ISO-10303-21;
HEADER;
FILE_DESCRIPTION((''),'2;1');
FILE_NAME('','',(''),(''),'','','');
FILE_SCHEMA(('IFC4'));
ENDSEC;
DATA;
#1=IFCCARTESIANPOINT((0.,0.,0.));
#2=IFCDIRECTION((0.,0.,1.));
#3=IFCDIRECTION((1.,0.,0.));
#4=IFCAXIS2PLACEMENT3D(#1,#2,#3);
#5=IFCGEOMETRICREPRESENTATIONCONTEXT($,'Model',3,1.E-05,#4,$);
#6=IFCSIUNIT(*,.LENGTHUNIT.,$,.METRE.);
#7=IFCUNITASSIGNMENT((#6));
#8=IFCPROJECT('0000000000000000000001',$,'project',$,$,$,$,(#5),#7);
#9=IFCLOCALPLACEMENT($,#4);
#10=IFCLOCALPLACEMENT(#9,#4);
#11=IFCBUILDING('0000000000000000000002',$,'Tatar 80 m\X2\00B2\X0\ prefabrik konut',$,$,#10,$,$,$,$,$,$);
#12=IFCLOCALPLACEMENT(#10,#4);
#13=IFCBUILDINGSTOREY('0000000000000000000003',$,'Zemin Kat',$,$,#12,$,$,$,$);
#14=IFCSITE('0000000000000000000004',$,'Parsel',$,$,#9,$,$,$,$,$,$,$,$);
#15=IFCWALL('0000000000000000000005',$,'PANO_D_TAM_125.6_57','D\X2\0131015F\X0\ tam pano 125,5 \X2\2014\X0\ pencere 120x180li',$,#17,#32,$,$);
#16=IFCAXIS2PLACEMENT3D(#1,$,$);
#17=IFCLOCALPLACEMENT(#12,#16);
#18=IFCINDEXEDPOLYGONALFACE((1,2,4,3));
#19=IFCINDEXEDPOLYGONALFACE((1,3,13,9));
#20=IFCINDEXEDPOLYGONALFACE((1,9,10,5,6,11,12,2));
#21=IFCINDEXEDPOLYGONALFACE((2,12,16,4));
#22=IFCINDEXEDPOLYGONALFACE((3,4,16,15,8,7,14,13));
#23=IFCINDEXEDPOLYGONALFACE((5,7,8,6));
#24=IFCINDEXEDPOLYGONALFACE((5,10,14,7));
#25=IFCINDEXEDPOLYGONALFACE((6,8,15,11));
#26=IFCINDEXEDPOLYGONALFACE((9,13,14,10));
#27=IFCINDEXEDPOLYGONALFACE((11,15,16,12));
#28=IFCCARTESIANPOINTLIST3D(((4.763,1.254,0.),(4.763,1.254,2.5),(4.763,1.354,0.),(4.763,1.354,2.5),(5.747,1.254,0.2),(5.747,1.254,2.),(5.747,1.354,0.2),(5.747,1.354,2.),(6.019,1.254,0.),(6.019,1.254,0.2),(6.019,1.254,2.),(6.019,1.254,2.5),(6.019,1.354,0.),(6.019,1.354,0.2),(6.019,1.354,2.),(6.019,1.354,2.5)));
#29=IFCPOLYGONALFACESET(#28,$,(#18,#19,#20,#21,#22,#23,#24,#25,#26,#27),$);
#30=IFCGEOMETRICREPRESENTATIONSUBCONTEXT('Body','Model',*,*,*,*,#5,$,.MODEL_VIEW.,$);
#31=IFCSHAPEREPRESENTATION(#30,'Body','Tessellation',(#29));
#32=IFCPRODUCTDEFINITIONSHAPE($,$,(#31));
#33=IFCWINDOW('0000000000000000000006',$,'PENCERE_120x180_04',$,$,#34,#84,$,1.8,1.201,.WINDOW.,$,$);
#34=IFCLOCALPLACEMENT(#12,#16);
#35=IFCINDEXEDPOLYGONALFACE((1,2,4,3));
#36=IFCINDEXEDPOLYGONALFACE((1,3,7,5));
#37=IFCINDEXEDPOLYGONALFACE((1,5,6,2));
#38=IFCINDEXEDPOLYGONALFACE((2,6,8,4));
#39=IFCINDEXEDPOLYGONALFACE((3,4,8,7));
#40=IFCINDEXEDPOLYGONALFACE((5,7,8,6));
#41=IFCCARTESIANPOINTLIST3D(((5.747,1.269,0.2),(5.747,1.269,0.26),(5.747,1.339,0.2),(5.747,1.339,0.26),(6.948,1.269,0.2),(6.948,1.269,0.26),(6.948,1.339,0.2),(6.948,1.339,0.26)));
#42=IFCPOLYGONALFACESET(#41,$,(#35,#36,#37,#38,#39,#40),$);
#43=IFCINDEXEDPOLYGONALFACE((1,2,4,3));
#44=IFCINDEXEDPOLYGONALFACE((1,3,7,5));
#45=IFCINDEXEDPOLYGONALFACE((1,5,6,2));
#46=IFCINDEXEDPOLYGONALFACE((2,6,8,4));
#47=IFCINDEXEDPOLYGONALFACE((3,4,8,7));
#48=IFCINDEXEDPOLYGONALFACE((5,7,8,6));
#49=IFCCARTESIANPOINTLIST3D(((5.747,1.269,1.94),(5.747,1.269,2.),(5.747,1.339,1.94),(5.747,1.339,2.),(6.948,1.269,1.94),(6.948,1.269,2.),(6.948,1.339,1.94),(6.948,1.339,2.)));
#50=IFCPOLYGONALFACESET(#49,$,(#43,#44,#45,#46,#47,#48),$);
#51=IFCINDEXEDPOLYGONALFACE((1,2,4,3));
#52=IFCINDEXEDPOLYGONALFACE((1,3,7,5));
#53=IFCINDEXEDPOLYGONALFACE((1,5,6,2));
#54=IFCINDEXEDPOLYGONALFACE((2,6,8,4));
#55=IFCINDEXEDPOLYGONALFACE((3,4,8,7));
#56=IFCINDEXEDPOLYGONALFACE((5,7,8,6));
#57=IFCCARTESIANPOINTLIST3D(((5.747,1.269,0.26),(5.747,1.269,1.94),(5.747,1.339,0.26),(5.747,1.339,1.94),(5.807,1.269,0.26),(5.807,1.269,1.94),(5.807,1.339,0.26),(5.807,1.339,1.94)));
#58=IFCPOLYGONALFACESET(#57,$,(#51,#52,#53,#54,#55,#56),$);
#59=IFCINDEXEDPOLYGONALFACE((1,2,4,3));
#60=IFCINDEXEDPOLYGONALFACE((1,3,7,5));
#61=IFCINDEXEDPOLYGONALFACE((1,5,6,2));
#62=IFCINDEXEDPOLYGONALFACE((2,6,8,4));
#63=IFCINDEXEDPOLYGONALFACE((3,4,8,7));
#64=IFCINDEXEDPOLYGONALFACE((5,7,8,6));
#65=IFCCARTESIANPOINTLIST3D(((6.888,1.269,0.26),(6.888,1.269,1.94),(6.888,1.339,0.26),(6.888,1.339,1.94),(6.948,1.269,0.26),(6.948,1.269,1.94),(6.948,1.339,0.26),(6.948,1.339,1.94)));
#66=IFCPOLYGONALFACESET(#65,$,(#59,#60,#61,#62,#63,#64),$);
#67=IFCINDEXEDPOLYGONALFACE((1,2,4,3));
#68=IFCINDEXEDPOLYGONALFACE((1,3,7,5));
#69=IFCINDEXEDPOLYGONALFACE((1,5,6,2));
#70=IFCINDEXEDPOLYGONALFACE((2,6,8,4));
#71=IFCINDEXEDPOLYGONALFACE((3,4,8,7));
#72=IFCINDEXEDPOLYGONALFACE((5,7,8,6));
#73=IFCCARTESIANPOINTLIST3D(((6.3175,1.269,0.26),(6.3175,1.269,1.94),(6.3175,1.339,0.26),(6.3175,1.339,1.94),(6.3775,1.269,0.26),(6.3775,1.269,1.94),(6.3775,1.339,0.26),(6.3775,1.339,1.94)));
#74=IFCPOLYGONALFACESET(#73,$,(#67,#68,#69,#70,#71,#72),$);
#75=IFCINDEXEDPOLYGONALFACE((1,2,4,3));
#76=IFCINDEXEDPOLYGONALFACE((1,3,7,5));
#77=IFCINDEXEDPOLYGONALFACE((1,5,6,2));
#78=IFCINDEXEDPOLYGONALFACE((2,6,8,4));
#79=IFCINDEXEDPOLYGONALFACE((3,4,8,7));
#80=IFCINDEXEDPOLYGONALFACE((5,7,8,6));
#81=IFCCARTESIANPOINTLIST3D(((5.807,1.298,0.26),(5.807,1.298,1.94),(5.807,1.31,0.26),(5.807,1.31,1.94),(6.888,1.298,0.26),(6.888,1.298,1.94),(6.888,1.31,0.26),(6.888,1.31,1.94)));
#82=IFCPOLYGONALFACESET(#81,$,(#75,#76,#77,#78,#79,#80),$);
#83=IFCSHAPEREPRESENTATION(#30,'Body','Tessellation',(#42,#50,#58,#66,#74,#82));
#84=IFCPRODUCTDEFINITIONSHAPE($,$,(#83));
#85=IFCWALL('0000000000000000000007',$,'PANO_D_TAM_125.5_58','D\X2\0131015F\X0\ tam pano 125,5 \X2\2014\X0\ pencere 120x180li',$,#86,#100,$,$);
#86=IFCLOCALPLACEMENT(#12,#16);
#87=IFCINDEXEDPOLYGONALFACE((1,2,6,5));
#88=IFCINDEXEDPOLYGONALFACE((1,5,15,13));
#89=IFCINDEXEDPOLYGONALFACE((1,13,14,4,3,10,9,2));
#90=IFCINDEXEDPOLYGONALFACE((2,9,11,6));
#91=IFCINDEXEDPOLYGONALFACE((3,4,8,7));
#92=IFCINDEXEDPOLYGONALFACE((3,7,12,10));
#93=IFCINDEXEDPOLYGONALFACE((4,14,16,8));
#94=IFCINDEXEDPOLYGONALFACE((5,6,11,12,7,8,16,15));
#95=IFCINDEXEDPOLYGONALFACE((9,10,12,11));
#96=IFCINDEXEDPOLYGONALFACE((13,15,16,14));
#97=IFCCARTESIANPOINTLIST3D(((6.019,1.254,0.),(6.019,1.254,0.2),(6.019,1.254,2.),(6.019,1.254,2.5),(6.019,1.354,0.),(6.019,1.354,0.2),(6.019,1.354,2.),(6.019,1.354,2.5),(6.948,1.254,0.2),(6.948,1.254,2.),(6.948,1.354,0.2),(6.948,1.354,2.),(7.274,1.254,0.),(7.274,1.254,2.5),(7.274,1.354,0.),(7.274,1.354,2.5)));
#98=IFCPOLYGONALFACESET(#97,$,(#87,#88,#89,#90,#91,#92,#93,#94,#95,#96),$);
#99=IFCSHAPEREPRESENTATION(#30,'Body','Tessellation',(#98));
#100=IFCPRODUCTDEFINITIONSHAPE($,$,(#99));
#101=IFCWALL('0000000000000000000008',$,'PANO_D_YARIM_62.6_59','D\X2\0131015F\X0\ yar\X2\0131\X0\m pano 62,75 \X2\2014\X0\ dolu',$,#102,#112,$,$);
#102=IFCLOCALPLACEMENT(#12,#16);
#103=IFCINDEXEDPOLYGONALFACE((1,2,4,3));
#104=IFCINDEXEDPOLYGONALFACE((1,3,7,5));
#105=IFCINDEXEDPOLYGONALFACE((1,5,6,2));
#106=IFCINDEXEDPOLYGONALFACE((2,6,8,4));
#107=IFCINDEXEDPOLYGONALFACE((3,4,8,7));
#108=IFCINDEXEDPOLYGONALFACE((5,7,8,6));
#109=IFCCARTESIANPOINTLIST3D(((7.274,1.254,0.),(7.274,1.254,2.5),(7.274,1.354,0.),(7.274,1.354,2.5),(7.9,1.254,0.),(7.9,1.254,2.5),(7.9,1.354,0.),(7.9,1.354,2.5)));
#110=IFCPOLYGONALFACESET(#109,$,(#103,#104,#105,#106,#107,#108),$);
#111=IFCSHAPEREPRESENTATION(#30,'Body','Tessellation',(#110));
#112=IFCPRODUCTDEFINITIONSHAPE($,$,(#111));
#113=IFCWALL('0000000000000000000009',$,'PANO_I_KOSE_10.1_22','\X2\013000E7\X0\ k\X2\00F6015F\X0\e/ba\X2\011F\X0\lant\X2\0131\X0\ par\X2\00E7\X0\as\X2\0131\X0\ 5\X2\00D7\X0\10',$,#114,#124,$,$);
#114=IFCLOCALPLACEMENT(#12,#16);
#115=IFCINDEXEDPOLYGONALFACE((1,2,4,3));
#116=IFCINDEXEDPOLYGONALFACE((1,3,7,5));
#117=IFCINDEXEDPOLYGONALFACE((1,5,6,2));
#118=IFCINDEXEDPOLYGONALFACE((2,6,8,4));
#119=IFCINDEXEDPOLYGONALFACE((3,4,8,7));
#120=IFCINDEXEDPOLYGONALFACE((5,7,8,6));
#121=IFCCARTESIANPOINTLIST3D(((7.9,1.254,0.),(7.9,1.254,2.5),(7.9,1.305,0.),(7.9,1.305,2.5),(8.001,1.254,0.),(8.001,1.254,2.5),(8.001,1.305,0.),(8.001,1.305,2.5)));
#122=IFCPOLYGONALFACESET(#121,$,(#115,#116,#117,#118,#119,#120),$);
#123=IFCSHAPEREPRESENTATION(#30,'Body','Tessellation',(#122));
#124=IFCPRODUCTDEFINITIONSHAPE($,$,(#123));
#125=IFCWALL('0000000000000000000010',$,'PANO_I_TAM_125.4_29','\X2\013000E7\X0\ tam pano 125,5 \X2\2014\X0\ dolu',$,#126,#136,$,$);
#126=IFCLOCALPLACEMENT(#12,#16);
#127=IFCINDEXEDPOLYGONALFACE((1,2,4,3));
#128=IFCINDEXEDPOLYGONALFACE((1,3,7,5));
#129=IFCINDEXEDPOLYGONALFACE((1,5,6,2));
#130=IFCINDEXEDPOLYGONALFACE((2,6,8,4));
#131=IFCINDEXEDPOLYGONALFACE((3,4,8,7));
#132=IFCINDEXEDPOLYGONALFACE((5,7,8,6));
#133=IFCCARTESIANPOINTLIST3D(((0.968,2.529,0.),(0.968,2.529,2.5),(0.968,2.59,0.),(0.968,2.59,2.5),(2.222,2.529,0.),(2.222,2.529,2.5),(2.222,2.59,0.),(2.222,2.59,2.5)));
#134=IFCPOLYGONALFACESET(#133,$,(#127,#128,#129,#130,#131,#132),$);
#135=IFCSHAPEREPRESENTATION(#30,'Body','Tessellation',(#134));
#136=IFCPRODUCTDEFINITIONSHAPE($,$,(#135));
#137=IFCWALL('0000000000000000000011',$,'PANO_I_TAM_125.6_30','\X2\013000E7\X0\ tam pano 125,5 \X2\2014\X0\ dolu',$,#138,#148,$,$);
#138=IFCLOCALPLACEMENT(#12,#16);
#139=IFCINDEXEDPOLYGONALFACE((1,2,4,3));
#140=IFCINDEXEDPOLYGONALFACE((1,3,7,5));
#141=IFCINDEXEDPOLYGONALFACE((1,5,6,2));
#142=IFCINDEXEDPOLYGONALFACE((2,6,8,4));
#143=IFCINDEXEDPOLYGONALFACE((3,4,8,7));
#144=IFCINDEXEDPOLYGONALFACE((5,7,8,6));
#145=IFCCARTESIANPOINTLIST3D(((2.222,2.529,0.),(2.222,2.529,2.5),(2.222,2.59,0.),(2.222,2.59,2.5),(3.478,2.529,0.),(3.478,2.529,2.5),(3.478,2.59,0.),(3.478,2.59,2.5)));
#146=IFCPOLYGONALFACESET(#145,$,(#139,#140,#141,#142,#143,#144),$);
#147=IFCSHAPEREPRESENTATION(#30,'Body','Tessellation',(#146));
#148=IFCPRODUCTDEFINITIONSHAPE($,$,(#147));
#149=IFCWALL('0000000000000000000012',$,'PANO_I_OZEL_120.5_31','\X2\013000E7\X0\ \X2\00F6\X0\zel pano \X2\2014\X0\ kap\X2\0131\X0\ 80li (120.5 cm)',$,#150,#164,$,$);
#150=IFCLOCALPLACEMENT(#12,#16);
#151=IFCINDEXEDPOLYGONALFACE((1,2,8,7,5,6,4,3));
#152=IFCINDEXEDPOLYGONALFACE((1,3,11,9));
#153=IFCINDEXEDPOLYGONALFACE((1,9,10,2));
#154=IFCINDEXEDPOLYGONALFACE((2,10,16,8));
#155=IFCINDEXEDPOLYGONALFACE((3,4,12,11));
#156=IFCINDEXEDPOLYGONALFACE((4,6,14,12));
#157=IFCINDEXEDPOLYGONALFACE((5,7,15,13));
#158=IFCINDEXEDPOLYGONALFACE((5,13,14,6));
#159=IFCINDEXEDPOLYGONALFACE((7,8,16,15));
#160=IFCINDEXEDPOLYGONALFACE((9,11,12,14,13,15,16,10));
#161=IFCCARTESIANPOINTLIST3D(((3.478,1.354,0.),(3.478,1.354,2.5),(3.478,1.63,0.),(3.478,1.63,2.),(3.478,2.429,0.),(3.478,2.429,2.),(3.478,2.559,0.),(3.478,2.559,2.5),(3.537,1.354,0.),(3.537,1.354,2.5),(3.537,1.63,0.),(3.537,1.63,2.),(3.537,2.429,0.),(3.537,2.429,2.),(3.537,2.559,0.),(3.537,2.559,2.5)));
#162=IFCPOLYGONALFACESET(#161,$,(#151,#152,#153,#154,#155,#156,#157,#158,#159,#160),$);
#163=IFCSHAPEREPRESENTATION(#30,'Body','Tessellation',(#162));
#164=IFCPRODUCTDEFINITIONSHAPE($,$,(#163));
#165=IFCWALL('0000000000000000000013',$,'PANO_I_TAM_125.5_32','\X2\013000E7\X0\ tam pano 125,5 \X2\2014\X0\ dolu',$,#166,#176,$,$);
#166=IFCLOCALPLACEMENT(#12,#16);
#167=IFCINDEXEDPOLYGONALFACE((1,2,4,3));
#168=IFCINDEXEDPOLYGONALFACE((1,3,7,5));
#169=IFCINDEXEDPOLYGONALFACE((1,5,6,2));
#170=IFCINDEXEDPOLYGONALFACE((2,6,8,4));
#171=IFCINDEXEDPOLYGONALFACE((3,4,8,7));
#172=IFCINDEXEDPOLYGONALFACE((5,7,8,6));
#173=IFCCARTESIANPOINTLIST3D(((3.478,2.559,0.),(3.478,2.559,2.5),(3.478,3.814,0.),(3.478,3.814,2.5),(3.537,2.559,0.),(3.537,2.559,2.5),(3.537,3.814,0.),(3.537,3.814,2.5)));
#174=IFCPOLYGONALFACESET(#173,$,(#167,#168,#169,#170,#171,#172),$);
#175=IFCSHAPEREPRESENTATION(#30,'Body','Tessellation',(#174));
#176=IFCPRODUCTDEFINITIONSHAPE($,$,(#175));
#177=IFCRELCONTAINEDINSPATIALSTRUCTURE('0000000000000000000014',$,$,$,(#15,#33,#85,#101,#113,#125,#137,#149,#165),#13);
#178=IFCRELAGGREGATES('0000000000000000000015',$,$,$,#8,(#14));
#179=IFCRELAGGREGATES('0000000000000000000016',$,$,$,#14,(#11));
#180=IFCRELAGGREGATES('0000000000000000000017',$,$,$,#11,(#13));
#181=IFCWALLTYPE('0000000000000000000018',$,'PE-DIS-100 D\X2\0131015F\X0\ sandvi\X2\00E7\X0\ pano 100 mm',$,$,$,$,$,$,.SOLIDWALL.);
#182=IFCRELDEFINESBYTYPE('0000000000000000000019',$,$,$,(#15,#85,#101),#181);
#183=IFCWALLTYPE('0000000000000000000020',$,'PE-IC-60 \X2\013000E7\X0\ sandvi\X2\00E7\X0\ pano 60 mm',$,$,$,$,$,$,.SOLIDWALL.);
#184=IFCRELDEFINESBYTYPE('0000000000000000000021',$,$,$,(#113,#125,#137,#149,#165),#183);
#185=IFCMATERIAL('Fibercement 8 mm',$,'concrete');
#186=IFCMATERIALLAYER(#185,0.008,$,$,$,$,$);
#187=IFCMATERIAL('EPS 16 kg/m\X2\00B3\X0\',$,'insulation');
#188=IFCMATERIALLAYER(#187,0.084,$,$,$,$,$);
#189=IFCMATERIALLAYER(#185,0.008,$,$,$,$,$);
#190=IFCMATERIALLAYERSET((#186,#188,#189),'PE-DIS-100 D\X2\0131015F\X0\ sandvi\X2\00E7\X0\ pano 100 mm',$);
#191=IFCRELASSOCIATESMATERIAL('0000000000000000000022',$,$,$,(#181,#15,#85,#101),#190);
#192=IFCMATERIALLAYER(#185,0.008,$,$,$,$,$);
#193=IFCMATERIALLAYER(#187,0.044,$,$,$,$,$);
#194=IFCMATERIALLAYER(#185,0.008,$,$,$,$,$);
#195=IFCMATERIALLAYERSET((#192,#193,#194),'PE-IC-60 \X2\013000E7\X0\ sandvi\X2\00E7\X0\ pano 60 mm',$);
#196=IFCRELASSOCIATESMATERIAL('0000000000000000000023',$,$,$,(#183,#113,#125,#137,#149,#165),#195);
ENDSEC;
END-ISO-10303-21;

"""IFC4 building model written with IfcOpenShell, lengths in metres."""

from ifc_helpers import new_model, si_unit, frame, origin_with_axes, place, context, subcontext, project, spatial, line, indexed_curve, outline, extrude, material, layer, layer_set, layer_usage, type_object, element, fill, save


model = new_model("IFC4")

# Units and contexts
model_context = context("Model", 3, precision=1e-05, world=origin_with_axes())
body_context = subcontext(model_context, "Body", "Model", "MODEL_VIEW")
ifc_project = project(units=[si_unit("LENGTHUNIT", "METRE")], contexts=[model_context])

# Site, building, storey
site_placement = place(None, origin_with_axes())
site = spatial("IfcSite", under=ifc_project, at=site_placement, Name="Parsel")
building_placement = place(site_placement, origin_with_axes())
building = spatial("IfcBuilding", under=site, at=building_placement, Name="Tatar 80 m² prefabrik konut")
storey_placement = place(building_placement, origin_with_axes())
storey = spatial("IfcBuildingStorey", under=building, at=storey_placement, Name="Zemin Kat")

# Shared definitions
ifc_material_1 = material(Name="Fibercement 8 mm", Category="concrete")
ifc_layer_1 = layer(ifc_material_1, 0.008)
ifc_material_2 = material(Name="EPS 16 kg/m³", Category="insulation")
ifc_layer_2 = layer(ifc_material_2, 0.084)
ifc_layer_3 = layer(ifc_material_1, 0.008)
ifc_layer_set_1 = layer_set([ifc_layer_1, ifc_layer_2, ifc_layer_3], Name="PE-DIS-100 Dış sandviç pano 100 mm")
wall_type_1 = type_object("IfcWallType", Name="PE-DIS-100 Dış sandviç pano 100 mm", PredefinedType="SOLIDWALL", material=ifc_layer_set_1)

# Wall, opening, window
ifc_layer_usage_1 = layer_usage(ifc_layer_set_1, "AXIS2", "POSITIVE", 0.0)
wall_1_placement = place(storey_placement, frame((4.763, 1.254, 0.0), z_axis=(0.0, 0.0, 1.0), x_axis=(1.0, 0.0, 0.0)))
wall_1 = element("IfcWall", 1, at=wall_1_placement, inside=storey, type_object=wall_type_1, material=ifc_layer_usage_1, Name="PANO_D_TAM_125.6_57", Description="Dış tam pano 125,5 — pencere 120x180li", context=body_context, shape_type="SweptSolid", body=[
    extrude(outline(indexed_curve([(0.0, 0.0), (1.256, 0.0), (1.256, 0.1), (0.0, 0.1)], segments=[line(1, 2, 3, 4, 1)])), origin_with_axes(), (0.0, 0.0, 1.0), 2.5),
])
opening_1_placement = place(wall_1_placement, origin_with_axes())
opening_1 = element("IfcOpeningElement", 2, at=opening_1_placement, cuts=wall_1, PredefinedType="OPENING", context=body_context, shape_type="SweptSolid", body=[
    extrude(outline(indexed_curve([(0.0, 0.0), (0.272, 0.0), (0.272, 0.14), (0.0, 0.14)], segments=[line(1, 2, 3, 4, 1)])), frame((0.984, -0.02, 0.2), z_axis=(0.0, 0.0, 1.0), x_axis=(1.0, 0.0, 0.0)), (0.0, 0.0, 1.0), 1.8),
])
window_1_placement = place(storey_placement, frame((4.763, 1.254, 0.0), z_axis=(0.0, 0.0, 1.0), x_axis=(1.0, 0.0, 0.0)))
window_1 = element("IfcWindow", 3, at=window_1_placement, inside=storey, Name="PENCERE_120x180_04", OverallHeight=1.8, OverallWidth=1.201, PredefinedType="WINDOW", context=body_context, shape_type="SweptSolid", body=[
    extrude(outline(indexed_curve([(0.0, 0.0), (1.201, 0.0), (1.201, 0.07), (0.0, 0.07)], segments=[line(1, 2, 3, 4, 1)])), frame((0.984, 0.015, 0.2), z_axis=(0.0, 0.0, 1.0), x_axis=(1.0, 0.0, 0.0)), (0.0, 0.0, 1.0), 0.06),
    extrude(outline(indexed_curve([(0.0, 0.0), (1.201, 0.0), (1.201, 0.07), (0.0, 0.07)], segments=[line(1, 2, 3, 4, 1)])), frame((0.984, 0.015, 1.94), z_axis=(0.0, 0.0, 1.0), x_axis=(1.0, 0.0, 0.0)), (0.0, 0.0, 1.0), 0.06),
    extrude(outline(indexed_curve([(0.0, 0.0), (0.06, 0.0), (0.06, 0.07), (0.0, 0.07)], segments=[line(1, 2, 3, 4, 1)])), frame((0.984, 0.015, 0.26), z_axis=(0.0, 0.0, 1.0), x_axis=(1.0, 0.0, 0.0)), (0.0, 0.0, 1.0), 1.68),
    extrude(outline(indexed_curve([(0.0, 0.0), (0.06, 0.0), (0.06, 0.07), (0.0, 0.07)], segments=[line(1, 2, 3, 4, 1)])), frame((2.125, 0.015, 0.26), z_axis=(0.0, 0.0, 1.0), x_axis=(1.0, 0.0, 0.0)), (0.0, 0.0, 1.0), 1.68),
    extrude(outline(indexed_curve([(0.0, 0.0), (0.06, 0.0), (0.06, 0.07), (0.0, 0.07)], segments=[line(1, 2, 3, 4, 1)])), frame((1.5545, 0.015, 0.26), z_axis=(0.0, 0.0, 1.0), x_axis=(1.0, 0.0, 0.0)), (0.0, 0.0, 1.0), 1.68),
    extrude(outline(indexed_curve([(0.0, 0.0), (1.081, 0.0), (1.081, 0.012), (0.0, 0.012)], segments=[line(1, 2, 3, 4, 1)])), frame((1.044, 0.044, 0.26), z_axis=(0.0, 0.0, 1.0), x_axis=(1.0, 0.0, 0.0)), (0.0, 0.0, 1.0), 1.68),
])
fill(opening_1, window_1)

# Wall, opening
ifc_layer_usage_2 = layer_usage(ifc_layer_set_1, "AXIS2", "POSITIVE", 0.0)
wall_2_placement = place(storey_placement, frame((6.019, 1.254, 0.0), z_axis=(0.0, 0.0, 1.0), x_axis=(1.0, 0.0, 0.0)))
wall_2 = element("IfcWall", 4, at=wall_2_placement, inside=storey, type_object=wall_type_1, material=ifc_layer_usage_2, Name="PANO_D_TAM_125.5_58", Description="Dış tam pano 125,5 — pencere 120x180li", context=body_context, shape_type="SweptSolid", body=[
    extrude(outline(indexed_curve([(0.0, 0.0), (1.255, 0.0), (1.255, 0.1), (0.0, 0.1)], segments=[line(1, 2, 3, 4, 1)])), origin_with_axes(), (0.0, 0.0, 1.0), 2.5),
])
opening_2_placement = place(wall_2_placement, origin_with_axes())
element("IfcOpeningElement", 5, at=opening_2_placement, cuts=wall_2, PredefinedType="OPENING", context=body_context, shape_type="SweptSolid", body=[
    extrude(outline(indexed_curve([(0.0, 0.0), (0.929, 0.0), (0.929, 0.14), (0.0, 0.14)], segments=[line(1, 2, 3, 4, 1)])), frame((0.0, -0.02, 0.2), z_axis=(0.0, 0.0, 1.0), x_axis=(1.0, 0.0, 0.0)), (0.0, 0.0, 1.0), 1.8),
])

# Walls
ifc_layer_usage_3 = layer_usage(ifc_layer_set_1, "AXIS2", "POSITIVE", 0.0)
wall_3_placement = place(storey_placement, frame((7.274, 1.254, 0.0), z_axis=(0.0, 0.0, 1.0), x_axis=(1.0, 0.0, 0.0)))
element("IfcWall", 6, at=wall_3_placement, inside=storey, type_object=wall_type_1, material=ifc_layer_usage_3, Name="PANO_D_YARIM_62.6_59", Description="Dış yarım pano 62,75 — dolu", context=body_context, shape_type="SweptSolid", body=[
    extrude(outline(indexed_curve([(0.0, 0.0), (0.626, 0.0), (0.626, 0.1), (0.0, 0.1)], segments=[line(1, 2, 3, 4, 1)])), origin_with_axes(), (0.0, 0.0, 1.0), 2.5),
])
ifc_layer_4 = layer(ifc_material_1, 0.008)
ifc_layer_5 = layer(ifc_material_2, 0.044)
ifc_layer_6 = layer(ifc_material_1, 0.008)
ifc_layer_set_2 = layer_set([ifc_layer_4, ifc_layer_5, ifc_layer_6], Name="PE-IC-60 İç sandviç pano 60 mm")
ifc_layer_usage_4 = layer_usage(ifc_layer_set_2, "AXIS2", "POSITIVE", 0.0)
wall_type_2 = type_object("IfcWallType", Name="PE-IC-60 İç sandviç pano 60 mm", PredefinedType="SOLIDWALL", material=ifc_layer_set_2)
wall_4_placement = place(storey_placement, frame((7.9, 1.254, 0.0), z_axis=(0.0, 0.0, 1.0), x_axis=(1.0, 0.0, 0.0)))
element("IfcWall", 7, at=wall_4_placement, inside=storey, type_object=wall_type_2, material=ifc_layer_usage_4, Name="PANO_I_KOSE_10.1_22", Description="İç köşe/bağlantı parçası 5×10", context=body_context, shape_type="SweptSolid", body=[
    extrude(outline(indexed_curve([(0.0, 0.0), (0.101, 0.0), (0.101, 0.051), (0.0, 0.051)], segments=[line(1, 2, 3, 4, 1)])), origin_with_axes(), (0.0, 0.0, 1.0), 2.5),
])
ifc_layer_usage_5 = layer_usage(ifc_layer_set_2, "AXIS2", "POSITIVE", 0.0)
wall_5_placement = place(storey_placement, frame((0.968, 2.529, 0.0), z_axis=(0.0, 0.0, 1.0), x_axis=(1.0, 0.0, 0.0)))
element("IfcWall", 8, at=wall_5_placement, inside=storey, type_object=wall_type_2, material=ifc_layer_usage_5, Name="PANO_I_TAM_125.4_29", Description="İç tam pano 125,5 — dolu", context=body_context, shape_type="SweptSolid", body=[
    extrude(outline(indexed_curve([(0.0, 0.0), (1.254, 0.0), (1.254, 0.061), (0.0, 0.061)], segments=[line(1, 2, 3, 4, 1)])), origin_with_axes(), (0.0, 0.0, 1.0), 2.5),
])
ifc_layer_usage_6 = layer_usage(ifc_layer_set_2, "AXIS2", "POSITIVE", 0.0)
wall_6_placement = place(storey_placement, frame((2.222, 2.529, 0.0), z_axis=(0.0, 0.0, 1.0), x_axis=(1.0, 0.0, 0.0)))
element("IfcWall", 9, at=wall_6_placement, inside=storey, type_object=wall_type_2, material=ifc_layer_usage_6, Name="PANO_I_TAM_125.6_30", Description="İç tam pano 125,5 — dolu", context=body_context, shape_type="SweptSolid", body=[
    extrude(outline(indexed_curve([(0.0, 0.0), (1.256, 0.0), (1.256, 0.061), (0.0, 0.061)], segments=[line(1, 2, 3, 4, 1)])), origin_with_axes(), (0.0, 0.0, 1.0), 2.5),
])

# Wall, opening
ifc_layer_usage_7 = layer_usage(ifc_layer_set_2, "AXIS2", "POSITIVE", 0.0)
wall_7_placement = place(storey_placement, frame((3.537, 1.354, 0.0), z_axis=(0.0, 0.0, 1.0), x_axis=(0.0, 1.0, 0.0)))
wall_7 = element("IfcWall", 10, at=wall_7_placement, inside=storey, type_object=wall_type_2, material=ifc_layer_usage_7, Name="PANO_I_OZEL_120.5_31", Description="İç özel pano — kapı 80li (120.5 cm)", context=body_context, shape_type="SweptSolid", body=[
    extrude(outline(indexed_curve([(0.0, 0.0), (1.205, 0.0), (1.205, 0.059), (0.0, 0.059)], segments=[line(1, 2, 3, 4, 1)])), origin_with_axes(), (0.0, 0.0, 1.0), 2.5),
])
opening_3_placement = place(wall_7_placement, origin_with_axes())
element("IfcOpeningElement", 11, at=opening_3_placement, cuts=wall_7, PredefinedType="OPENING", context=body_context, shape_type="SweptSolid", body=[
    extrude(outline(indexed_curve([(0.0, 0.0), (0.799, 0.0), (0.799, 0.099), (0.0, 0.099)], segments=[line(1, 2, 3, 4, 1)])), frame((0.276, -0.02, 0.0), z_axis=(0.0, 0.0, 1.0), x_axis=(1.0, 0.0, 0.0)), (0.0, 0.0, 1.0), 2.0),
])

# Wall
ifc_layer_usage_8 = layer_usage(ifc_layer_set_2, "AXIS2", "POSITIVE", 0.0)
wall_8_placement = place(storey_placement, frame((3.537, 2.559, 0.0), z_axis=(0.0, 0.0, 1.0), x_axis=(0.0, 1.0, 0.0)))
element("IfcWall", 12, at=wall_8_placement, inside=storey, type_object=wall_type_2, material=ifc_layer_usage_8, Name="PANO_I_TAM_125.5_32", Description="İç tam pano 125,5 — dolu", context=body_context, shape_type="SweptSolid", body=[
    extrude(outline(indexed_curve([(0.0, 0.0), (1.255, 0.0), (1.255, 0.059), (0.0, 0.059)], segments=[line(1, 2, 3, 4, 1)])), origin_with_axes(), (0.0, 0.0, 1.0), 2.5),
])

save(model, "model.ifc")
